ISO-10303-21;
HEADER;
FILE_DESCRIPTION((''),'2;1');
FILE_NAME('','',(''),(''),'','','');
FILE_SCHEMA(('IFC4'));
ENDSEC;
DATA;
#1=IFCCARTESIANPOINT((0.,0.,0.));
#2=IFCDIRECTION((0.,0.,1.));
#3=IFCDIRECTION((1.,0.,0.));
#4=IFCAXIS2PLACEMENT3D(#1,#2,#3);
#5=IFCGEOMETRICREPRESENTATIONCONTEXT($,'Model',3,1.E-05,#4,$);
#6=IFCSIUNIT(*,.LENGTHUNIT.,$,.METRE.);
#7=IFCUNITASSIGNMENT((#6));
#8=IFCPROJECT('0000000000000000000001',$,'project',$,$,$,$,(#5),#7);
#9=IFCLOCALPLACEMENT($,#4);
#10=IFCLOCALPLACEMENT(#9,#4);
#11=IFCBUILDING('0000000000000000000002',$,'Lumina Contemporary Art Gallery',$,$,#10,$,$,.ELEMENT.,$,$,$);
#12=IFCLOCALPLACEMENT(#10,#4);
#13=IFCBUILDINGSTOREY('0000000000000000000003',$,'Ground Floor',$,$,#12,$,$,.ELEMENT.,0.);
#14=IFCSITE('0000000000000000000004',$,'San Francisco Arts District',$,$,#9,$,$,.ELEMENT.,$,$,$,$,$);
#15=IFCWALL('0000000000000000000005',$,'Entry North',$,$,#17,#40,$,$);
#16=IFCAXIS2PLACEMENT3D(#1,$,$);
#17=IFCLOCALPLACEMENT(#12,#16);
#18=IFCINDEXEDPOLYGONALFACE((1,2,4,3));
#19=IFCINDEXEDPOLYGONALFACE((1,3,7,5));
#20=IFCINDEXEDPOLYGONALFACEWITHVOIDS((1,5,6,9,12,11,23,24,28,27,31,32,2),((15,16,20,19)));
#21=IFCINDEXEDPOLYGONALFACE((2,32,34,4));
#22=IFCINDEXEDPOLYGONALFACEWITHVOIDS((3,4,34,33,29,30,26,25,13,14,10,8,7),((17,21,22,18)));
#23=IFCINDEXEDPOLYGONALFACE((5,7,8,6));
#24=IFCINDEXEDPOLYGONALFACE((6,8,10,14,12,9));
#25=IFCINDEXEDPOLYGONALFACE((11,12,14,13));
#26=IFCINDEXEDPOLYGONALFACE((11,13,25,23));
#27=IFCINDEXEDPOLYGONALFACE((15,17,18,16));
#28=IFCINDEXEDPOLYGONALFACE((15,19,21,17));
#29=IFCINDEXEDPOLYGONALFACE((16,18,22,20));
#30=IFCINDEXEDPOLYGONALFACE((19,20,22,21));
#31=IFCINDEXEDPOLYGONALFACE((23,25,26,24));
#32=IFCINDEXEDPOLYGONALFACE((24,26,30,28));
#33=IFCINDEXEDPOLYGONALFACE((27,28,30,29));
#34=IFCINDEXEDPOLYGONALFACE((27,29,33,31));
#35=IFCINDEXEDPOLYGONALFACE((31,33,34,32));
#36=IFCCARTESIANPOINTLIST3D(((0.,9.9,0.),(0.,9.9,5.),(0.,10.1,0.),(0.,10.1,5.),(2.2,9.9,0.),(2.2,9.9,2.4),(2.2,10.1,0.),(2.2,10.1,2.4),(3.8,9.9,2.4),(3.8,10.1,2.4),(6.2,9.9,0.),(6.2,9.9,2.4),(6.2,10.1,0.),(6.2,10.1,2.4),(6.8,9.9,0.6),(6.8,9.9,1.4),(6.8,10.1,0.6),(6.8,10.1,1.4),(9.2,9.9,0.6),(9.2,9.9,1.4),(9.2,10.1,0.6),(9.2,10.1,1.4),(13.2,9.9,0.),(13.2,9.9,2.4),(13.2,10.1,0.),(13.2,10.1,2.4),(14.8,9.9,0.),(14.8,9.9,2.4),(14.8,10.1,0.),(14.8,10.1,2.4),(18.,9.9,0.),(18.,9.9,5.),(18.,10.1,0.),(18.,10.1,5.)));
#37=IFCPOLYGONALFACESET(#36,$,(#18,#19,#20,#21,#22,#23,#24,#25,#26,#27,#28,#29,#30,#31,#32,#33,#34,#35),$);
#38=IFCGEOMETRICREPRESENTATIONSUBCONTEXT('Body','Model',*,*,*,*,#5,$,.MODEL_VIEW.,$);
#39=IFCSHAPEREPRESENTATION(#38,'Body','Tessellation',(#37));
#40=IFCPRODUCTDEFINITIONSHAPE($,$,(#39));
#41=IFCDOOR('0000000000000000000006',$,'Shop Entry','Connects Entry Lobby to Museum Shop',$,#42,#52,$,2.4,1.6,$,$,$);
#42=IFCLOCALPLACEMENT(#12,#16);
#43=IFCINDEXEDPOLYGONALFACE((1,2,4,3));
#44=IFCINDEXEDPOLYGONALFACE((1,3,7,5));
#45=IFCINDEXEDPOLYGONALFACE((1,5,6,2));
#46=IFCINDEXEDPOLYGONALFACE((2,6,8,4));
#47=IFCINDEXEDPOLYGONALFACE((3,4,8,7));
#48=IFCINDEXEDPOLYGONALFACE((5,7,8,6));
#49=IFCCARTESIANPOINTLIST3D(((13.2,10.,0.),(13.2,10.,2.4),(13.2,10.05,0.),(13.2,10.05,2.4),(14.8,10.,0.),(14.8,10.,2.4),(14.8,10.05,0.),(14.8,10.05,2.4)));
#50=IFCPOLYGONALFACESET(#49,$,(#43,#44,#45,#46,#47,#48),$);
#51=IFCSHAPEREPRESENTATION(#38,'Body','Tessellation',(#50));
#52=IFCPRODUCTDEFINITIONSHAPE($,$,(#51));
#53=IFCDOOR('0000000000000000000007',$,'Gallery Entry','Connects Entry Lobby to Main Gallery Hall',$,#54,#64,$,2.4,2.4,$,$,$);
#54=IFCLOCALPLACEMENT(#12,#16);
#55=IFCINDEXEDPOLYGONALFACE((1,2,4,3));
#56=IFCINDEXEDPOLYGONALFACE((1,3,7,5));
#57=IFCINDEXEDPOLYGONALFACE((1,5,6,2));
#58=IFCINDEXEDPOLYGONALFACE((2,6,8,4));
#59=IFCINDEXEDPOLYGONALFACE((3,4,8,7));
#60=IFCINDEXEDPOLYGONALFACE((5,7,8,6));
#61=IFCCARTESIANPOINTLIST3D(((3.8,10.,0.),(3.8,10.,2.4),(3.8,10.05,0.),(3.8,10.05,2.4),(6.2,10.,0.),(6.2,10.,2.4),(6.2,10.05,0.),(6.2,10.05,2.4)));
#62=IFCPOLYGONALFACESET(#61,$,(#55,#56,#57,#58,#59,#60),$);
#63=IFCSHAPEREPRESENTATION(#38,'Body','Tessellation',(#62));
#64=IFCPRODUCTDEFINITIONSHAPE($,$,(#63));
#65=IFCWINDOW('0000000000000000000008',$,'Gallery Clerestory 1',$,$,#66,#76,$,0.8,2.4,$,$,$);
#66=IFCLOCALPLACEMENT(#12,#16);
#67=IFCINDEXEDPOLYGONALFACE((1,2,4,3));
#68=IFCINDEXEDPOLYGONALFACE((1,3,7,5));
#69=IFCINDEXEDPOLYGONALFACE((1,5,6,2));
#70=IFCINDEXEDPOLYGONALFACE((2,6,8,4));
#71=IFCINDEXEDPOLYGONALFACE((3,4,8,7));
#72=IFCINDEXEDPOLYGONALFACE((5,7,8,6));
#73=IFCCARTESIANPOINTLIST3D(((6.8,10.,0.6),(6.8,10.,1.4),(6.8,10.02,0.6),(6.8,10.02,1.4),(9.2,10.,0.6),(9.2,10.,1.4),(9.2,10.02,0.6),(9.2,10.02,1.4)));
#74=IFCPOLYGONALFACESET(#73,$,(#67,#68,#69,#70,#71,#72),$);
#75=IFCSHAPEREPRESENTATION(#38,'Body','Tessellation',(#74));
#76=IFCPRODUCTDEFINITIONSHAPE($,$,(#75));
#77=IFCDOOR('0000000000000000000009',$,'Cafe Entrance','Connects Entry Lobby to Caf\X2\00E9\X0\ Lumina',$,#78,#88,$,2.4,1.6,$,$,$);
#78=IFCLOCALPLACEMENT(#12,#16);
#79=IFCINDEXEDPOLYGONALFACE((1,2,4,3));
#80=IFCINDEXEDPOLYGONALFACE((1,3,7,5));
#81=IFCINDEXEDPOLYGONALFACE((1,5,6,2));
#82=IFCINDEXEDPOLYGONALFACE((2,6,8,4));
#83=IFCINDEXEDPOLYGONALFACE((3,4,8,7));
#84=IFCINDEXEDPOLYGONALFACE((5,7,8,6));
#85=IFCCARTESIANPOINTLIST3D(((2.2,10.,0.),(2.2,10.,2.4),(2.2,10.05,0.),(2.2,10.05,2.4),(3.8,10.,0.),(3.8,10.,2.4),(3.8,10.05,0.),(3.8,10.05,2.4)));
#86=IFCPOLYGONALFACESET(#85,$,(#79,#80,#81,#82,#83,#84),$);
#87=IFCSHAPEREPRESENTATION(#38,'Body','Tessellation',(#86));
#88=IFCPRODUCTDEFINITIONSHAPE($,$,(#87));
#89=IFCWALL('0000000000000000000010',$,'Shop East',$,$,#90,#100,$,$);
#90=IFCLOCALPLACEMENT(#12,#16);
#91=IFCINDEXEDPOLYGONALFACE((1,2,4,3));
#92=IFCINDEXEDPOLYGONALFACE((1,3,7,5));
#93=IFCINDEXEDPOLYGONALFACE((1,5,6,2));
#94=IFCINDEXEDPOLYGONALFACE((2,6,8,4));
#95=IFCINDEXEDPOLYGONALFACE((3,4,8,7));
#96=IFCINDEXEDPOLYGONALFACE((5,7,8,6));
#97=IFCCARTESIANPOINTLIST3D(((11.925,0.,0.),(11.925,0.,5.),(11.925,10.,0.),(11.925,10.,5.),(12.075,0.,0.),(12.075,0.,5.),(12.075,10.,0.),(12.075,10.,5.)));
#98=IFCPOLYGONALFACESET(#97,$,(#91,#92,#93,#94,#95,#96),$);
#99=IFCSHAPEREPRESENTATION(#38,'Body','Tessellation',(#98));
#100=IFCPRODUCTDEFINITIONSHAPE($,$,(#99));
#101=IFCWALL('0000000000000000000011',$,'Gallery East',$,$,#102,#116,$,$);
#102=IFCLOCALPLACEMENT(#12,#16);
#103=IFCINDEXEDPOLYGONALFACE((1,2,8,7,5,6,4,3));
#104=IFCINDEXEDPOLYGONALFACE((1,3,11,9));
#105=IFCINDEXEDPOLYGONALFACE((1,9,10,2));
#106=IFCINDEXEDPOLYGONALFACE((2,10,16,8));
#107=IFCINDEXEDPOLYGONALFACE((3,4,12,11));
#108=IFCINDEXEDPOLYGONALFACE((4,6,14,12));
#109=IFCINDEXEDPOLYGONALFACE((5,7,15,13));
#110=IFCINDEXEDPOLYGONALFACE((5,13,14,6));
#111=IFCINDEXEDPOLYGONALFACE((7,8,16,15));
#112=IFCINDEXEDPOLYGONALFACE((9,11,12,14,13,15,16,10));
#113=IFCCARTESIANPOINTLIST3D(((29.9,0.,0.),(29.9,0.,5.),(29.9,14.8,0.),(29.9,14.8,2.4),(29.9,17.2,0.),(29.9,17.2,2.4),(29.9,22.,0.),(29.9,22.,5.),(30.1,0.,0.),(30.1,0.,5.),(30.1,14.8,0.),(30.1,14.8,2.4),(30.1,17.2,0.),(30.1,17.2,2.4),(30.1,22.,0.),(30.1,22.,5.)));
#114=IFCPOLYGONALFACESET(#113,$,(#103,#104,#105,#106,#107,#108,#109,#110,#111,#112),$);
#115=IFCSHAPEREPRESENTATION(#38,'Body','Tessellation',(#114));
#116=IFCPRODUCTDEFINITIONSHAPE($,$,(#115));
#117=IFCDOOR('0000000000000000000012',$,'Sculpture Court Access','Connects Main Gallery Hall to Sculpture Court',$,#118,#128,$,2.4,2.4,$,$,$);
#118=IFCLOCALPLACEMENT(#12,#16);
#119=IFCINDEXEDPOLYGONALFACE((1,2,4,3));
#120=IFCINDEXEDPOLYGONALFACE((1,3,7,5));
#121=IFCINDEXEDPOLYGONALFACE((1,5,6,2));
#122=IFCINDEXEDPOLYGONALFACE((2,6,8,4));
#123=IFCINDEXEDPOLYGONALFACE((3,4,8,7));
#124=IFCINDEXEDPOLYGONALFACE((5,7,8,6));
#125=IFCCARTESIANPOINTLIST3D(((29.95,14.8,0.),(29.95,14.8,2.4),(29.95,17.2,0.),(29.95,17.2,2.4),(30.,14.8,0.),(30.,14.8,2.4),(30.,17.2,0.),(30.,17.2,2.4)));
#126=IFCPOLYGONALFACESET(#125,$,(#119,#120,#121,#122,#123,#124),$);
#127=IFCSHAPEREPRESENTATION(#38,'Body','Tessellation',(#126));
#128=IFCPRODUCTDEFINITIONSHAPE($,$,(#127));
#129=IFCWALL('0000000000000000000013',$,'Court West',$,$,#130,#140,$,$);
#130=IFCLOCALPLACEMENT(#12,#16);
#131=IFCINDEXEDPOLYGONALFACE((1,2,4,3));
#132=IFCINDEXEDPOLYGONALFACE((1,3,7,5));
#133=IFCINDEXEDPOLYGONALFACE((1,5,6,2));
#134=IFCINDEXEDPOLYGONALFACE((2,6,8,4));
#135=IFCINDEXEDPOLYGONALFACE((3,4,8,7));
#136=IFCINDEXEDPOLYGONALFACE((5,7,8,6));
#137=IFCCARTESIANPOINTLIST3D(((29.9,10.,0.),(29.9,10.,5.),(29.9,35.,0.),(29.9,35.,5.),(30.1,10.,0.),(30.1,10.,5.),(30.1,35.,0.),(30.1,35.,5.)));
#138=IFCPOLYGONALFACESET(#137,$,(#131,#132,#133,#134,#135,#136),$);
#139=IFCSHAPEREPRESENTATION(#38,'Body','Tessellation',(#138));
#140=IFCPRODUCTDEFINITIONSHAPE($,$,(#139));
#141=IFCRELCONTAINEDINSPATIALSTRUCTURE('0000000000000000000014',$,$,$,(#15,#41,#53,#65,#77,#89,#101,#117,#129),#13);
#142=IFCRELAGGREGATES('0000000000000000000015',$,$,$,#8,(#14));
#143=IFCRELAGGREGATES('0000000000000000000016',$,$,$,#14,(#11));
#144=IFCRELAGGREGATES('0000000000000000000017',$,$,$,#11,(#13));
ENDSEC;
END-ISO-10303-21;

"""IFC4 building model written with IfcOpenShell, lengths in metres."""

from ifc_helpers import new_model, si_unit, origin_with_axes, place, context, subcontext, project, spatial, polyline, outline, extrude, element, fill, save


model = new_model("IFC4")

# Units and contexts
model_context = context("Model", 3, precision=1e-05, world=origin_with_axes())
body_context = subcontext(model_context, "Body", "Model", "MODEL_VIEW")
ifc_project = project(units=[si_unit("LENGTHUNIT", "METRE")], contexts=[model_context])

# Site, building, storey
site_placement = place(None, origin_with_axes())
site = spatial("IfcSite", under=ifc_project, at=site_placement, Name="San Francisco Arts District", CompositionType="ELEMENT")
building_placement = place(site_placement, origin_with_axes())
building = spatial("IfcBuilding", under=site, at=building_placement, Name="Lumina Contemporary Art Gallery", CompositionType="ELEMENT")
storey_placement = place(building_placement, origin_with_axes())
storey = spatial("IfcBuildingStorey", under=building, at=storey_placement, Name="Ground Floor", CompositionType="ELEMENT", Elevation=0.0)

# Wall, openings, doors, window
wall_1_placement = place(storey_placement, origin_with_axes())
wall_1 = element("IfcWall", 1, at=wall_1_placement, inside=storey, Name="Entry North", context=body_context, shape_type="SweptSolid", body=[
    extrude(outline(polyline([(0.0, 9.9, 0.0), (18.0, 9.9, 0.0), (18.0, 10.1, 0.0), (0.0, 10.1, 0.0), (0.0, 9.9, 0.0)])), None, (0.0, 0.0, 1.0), 5.0),
])
opening_1_placement = place(storey_placement, origin_with_axes())
opening_1 = element("IfcOpeningElement", 2, at=opening_1_placement, inside=storey, cuts=wall_1, context=body_context, shape_type="SweptSolid", body=[
    extrude(outline(polyline([(13.2, 9.8, 0.0), (14.8, 9.8, 0.0), (14.8, 10.2, 0.0), (13.2, 10.2, 0.0), (13.2, 9.8, 0.0)])), None, (0.0, 0.0, 1.0), 2.4),
])
opening_2_placement = place(storey_placement, origin_with_axes())
opening_2 = element("IfcOpeningElement", 3, at=opening_2_placement, inside=storey, cuts=wall_1, context=body_context, shape_type="SweptSolid", body=[
    extrude(outline(polyline([(3.8, 9.8, 0.0), (6.2, 9.8, 0.0), (6.2, 10.2, 0.0), (3.8, 10.2, 0.0), (3.8, 9.8, 0.0)])), None, (0.0, 0.0, 1.0), 2.4),
])
opening_3_placement = place(storey_placement, origin_with_axes())
opening_3 = element("IfcOpeningElement", 4, at=opening_3_placement, inside=storey, cuts=wall_1, context=body_context, shape_type="SweptSolid", body=[
    extrude(outline(polyline([(6.8, 9.8, 0.6), (9.2, 9.8, 0.6), (9.2, 10.2, 0.6), (6.8, 10.2, 0.6), (6.8, 9.8, 0.6)])), None, (0.0, 0.0, 1.0), 0.8),
])
opening_4_placement = place(storey_placement, origin_with_axes())
opening_4 = element("IfcOpeningElement", 5, at=opening_4_placement, inside=storey, cuts=wall_1, context=body_context, shape_type="SweptSolid", body=[
    extrude(outline(polyline([(2.2, 9.8, 0.0), (3.8, 9.8, 0.0), (3.8, 10.2, 0.0), (2.2, 10.2, 0.0), (2.2, 9.8, 0.0)])), None, (0.0, 0.0, 1.0), 2.4),
])
door_1_placement = place(storey_placement, origin_with_axes())
door_1 = element("IfcDoor", 6, at=door_1_placement, inside=storey, Name="Shop Entry", Description="Connects Entry Lobby to Museum Shop", OverallHeight=2.4, OverallWidth=1.6, context=body_context, shape_type="SweptSolid", body=[
    extrude(outline(polyline([(13.2, 10.0, 0.0), (14.8, 10.0, 0.0), (14.8, 10.05, 0.0), (13.2, 10.05, 0.0), (13.2, 10.0, 0.0)])), None, (0.0, 0.0, 1.0), 2.4),
])
fill(opening_1, door_1)
door_2_placement = place(storey_placement, origin_with_axes())
door_2 = element("IfcDoor", 7, at=door_2_placement, inside=storey, Name="Gallery Entry", Description="Connects Entry Lobby to Main Gallery Hall", OverallHeight=2.4, OverallWidth=2.4, context=body_context, shape_type="SweptSolid", body=[
    extrude(outline(polyline([(3.8, 10.0, 0.0), (6.2, 10.0, 0.0), (6.2, 10.05, 0.0), (3.8, 10.05, 0.0), (3.8, 10.0, 0.0)])), None, (0.0, 0.0, 1.0), 2.4),
])
fill(opening_2, door_2)
window_placement = place(storey_placement, origin_with_axes())
window = element("IfcWindow", 8, at=window_placement, inside=storey, Name="Gallery Clerestory 1", OverallHeight=0.8, OverallWidth=2.4, context=body_context, shape_type="SweptSolid", body=[
    extrude(outline(polyline([(6.8, 10.0, 0.6), (9.2, 10.0, 0.6), (9.2, 10.02, 0.6), (6.8, 10.02, 0.6), (6.8, 10.0, 0.6)])), None, (0.0, 0.0, 1.0), 0.8),
])
fill(opening_3, window)
door_3_placement = place(storey_placement, origin_with_axes())
door_3 = element("IfcDoor", 9, at=door_3_placement, inside=storey, Name="Cafe Entrance", Description="Connects Entry Lobby to Café Lumina", OverallHeight=2.4, OverallWidth=1.6, context=body_context, shape_type="SweptSolid", body=[
    extrude(outline(polyline([(2.2, 10.0, 0.0), (3.8, 10.0, 0.0), (3.8, 10.05, 0.0), (2.2, 10.05, 0.0), (2.2, 10.0, 0.0)])), None, (0.0, 0.0, 1.0), 2.4),
])
fill(opening_4, door_3)

# Wall
wall_2_placement = place(storey_placement, origin_with_axes())
element("IfcWall", 10, at=wall_2_placement, inside=storey, Name="Shop East", context=body_context, shape_type="SweptSolid", body=[
    extrude(outline(polyline([(12.075, 0.0, 0.0), (12.075, 10.0, 0.0), (11.925, 10.0, 0.0), (11.925, 0.0, 0.0), (12.075, 0.0, 0.0)])), None, (0.0, 0.0, 1.0), 5.0),
])

# Wall, opening, door
wall_3_placement = place(storey_placement, origin_with_axes())
wall_3 = element("IfcWall", 11, at=wall_3_placement, inside=storey, Name="Gallery East", context=body_context, shape_type="SweptSolid", body=[
    extrude(outline(polyline([(30.1, 0.0, 0.0), (30.1, 22.0, 0.0), (29.9, 22.0, 0.0), (29.9, 0.0, 0.0), (30.1, 0.0, 0.0)])), None, (0.0, 0.0, 1.0), 5.0),
])
opening_5_placement = place(storey_placement, origin_with_axes())
opening_5 = element("IfcOpeningElement", 12, at=opening_5_placement, inside=storey, cuts=wall_3, context=body_context, shape_type="SweptSolid", body=[
    extrude(outline(polyline([(30.2, 14.8, 0.0), (30.2, 17.2, 0.0), (29.8, 17.2, 0.0), (29.8, 14.8, 0.0), (30.2, 14.8, 0.0)])), None, (0.0, 0.0, 1.0), 2.4),
])
door_4_placement = place(storey_placement, origin_with_axes())
door_4 = element("IfcDoor", 13, at=door_4_placement, inside=storey, Name="Sculpture Court Access", Description="Connects Main Gallery Hall to Sculpture Court", OverallHeight=2.4, OverallWidth=2.4, context=body_context, shape_type="SweptSolid", body=[
    extrude(outline(polyline([(30.0, 14.8, 0.0), (30.0, 17.2, 0.0), (29.95, 17.2, 0.0), (29.95, 14.8, 0.0), (30.0, 14.8, 0.0)])), None, (0.0, 0.0, 1.0), 2.4),
])
fill(opening_5, door_4)

# Wall
wall_4_placement = place(storey_placement, origin_with_axes())
element("IfcWall", 14, at=wall_4_placement, inside=storey, Name="Court West", context=body_context, shape_type="SweptSolid", body=[
    extrude(outline(polyline([(30.1, 10.0, 0.0), (30.1, 35.0, 0.0), (29.9, 35.0, 0.0), (29.9, 10.0, 0.0), (30.1, 10.0, 0.0)])), None, (0.0, 0.0, 1.0), 5.0),
])

save(model, "model.ifc")
